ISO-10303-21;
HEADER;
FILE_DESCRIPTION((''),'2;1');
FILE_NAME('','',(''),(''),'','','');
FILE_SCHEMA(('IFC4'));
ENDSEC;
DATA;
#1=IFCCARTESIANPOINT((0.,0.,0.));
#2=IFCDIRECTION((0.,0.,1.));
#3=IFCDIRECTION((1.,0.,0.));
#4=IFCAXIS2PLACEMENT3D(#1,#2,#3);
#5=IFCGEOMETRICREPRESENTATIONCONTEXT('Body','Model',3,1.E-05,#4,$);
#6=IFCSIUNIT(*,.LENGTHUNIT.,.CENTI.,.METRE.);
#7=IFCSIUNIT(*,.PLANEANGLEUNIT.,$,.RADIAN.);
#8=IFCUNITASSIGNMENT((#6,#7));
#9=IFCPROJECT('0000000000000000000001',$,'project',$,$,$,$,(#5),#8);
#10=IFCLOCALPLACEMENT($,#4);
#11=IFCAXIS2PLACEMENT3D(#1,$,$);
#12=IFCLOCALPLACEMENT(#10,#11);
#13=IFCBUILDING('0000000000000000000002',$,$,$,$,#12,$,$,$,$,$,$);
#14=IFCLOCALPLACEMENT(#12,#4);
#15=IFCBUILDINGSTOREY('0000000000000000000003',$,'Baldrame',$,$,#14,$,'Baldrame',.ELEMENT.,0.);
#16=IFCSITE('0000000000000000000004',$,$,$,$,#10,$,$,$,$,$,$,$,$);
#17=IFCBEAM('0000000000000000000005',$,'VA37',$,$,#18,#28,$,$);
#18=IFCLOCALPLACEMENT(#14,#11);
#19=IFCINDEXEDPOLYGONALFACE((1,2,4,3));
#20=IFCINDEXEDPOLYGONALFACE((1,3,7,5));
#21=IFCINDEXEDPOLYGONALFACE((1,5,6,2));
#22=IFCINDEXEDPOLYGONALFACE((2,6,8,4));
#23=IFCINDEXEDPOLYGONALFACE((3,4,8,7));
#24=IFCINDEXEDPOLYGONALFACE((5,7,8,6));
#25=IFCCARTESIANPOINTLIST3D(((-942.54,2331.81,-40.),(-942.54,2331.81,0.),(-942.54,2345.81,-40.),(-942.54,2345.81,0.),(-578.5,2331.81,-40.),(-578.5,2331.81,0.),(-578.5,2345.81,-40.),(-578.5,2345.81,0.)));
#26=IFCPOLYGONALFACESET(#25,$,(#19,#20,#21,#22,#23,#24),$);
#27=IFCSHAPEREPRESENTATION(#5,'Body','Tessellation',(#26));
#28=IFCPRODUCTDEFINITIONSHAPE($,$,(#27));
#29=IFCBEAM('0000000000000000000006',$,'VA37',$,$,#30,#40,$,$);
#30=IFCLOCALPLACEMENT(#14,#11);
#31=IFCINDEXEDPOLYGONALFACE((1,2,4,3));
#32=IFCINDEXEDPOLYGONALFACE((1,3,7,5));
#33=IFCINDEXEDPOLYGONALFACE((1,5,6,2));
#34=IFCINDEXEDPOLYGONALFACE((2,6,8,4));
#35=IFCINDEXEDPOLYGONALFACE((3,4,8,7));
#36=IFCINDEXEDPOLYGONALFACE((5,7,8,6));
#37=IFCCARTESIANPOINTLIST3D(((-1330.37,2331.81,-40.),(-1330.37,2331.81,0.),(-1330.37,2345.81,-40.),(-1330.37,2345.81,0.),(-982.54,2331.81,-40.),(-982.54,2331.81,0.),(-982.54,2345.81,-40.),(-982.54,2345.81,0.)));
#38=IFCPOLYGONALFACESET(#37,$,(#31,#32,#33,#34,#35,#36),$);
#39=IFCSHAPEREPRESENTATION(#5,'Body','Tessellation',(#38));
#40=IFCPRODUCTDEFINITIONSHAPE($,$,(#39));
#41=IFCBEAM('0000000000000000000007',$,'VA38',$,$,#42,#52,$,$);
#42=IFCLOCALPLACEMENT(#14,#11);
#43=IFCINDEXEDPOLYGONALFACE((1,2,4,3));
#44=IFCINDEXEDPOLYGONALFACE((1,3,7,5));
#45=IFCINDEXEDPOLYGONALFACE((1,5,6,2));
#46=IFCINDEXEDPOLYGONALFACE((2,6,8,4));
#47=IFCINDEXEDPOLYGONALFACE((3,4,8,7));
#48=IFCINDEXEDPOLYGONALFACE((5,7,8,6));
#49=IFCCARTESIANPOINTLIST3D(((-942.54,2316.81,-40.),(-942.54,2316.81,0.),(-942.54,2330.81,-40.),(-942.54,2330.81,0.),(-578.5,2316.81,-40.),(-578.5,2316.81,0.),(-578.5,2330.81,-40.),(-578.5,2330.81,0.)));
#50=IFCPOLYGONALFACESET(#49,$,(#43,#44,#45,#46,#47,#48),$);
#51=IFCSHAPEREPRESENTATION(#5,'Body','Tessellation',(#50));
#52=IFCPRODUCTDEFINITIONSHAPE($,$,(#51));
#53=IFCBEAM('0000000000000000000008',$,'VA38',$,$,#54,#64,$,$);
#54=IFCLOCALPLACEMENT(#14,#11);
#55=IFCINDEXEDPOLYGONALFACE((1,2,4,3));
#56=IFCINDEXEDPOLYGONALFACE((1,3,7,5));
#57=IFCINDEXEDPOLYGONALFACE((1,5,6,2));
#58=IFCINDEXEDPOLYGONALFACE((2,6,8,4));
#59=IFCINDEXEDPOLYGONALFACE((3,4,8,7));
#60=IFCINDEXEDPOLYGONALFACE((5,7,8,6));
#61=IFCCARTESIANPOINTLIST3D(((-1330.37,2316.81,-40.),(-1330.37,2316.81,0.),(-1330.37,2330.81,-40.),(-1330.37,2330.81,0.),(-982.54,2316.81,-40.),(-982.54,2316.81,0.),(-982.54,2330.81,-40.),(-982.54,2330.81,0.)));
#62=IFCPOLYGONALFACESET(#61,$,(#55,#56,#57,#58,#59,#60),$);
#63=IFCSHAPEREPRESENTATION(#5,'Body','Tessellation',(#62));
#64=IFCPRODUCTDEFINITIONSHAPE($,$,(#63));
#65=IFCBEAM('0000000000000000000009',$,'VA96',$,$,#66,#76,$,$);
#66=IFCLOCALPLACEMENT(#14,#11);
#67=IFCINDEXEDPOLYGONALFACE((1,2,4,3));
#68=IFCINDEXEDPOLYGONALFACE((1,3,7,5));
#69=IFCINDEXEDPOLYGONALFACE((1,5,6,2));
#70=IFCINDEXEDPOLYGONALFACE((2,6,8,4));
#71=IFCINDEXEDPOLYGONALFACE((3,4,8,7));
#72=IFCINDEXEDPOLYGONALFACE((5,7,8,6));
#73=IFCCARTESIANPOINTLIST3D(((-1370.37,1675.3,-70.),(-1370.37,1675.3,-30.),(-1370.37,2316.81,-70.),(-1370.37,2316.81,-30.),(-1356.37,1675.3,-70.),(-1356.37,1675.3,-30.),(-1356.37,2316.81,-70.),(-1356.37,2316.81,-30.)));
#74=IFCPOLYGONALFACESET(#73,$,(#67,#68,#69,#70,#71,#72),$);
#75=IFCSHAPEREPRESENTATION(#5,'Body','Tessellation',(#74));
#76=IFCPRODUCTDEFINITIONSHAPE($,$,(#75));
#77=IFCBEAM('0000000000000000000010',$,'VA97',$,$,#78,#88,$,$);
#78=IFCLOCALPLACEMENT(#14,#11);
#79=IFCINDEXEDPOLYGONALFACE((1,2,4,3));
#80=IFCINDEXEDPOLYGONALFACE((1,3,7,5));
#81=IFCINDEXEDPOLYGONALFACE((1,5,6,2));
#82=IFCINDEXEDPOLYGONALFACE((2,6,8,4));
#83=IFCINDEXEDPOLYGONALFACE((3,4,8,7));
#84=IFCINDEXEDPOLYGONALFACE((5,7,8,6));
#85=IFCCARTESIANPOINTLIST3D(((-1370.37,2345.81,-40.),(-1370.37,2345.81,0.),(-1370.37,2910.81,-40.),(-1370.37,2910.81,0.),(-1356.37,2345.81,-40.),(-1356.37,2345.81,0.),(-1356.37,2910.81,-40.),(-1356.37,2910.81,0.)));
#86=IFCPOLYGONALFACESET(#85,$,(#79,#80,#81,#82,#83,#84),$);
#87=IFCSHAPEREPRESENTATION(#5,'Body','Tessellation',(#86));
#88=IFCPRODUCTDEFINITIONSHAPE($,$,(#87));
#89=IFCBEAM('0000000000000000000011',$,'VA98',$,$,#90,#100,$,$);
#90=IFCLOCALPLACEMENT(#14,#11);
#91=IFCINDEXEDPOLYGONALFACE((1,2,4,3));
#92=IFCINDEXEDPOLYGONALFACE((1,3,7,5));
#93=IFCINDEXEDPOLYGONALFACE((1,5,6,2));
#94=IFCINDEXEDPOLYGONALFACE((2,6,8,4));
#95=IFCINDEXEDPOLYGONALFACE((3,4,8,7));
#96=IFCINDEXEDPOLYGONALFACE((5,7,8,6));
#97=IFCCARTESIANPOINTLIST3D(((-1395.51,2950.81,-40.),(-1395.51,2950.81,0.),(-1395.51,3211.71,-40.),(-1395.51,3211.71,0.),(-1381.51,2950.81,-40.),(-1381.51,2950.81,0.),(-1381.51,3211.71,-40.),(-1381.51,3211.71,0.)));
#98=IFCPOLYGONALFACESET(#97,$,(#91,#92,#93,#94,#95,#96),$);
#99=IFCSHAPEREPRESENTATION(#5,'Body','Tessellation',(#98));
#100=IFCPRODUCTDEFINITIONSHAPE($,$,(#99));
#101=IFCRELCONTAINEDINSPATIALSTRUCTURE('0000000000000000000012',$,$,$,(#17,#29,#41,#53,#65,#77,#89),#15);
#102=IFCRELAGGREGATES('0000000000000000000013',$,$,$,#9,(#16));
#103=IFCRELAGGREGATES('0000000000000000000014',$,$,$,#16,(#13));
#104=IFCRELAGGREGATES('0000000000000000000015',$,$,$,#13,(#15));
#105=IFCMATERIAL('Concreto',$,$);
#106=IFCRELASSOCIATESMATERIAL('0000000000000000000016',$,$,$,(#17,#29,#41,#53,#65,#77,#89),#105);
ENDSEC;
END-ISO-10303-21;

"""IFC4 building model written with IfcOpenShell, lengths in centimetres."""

from ifc_helpers import new_model, si_unit, frame, origin, origin_with_axes, origin_2d_with_axis, place, context, project, spatial, rectangle, extrude, material, element, save


model = new_model("IFC4")

# Units and contexts
model_context = context("Model", 3, precision=1e-05, world=origin_with_axes(), identifier="Body")
ifc_project = project(units=[si_unit("LENGTHUNIT", "METRE", prefix="CENTI"), si_unit("PLANEANGLEUNIT", "RADIAN")], contexts=[model_context])

# Site, building, storey
site_placement = place(None, origin_with_axes())
site = spatial("IfcSite", under=ifc_project, at=site_placement)
building_placement = place(site_placement, origin())
building = spatial("IfcBuilding", under=site, at=building_placement)
storey_placement = place(building_placement, origin_with_axes())
storey = spatial("IfcBuildingStorey", under=building, at=storey_placement, Name="Baldrame", LongName="Baldrame", CompositionType="ELEMENT", Elevation=0.0)

# Shared definitions
ifc_material = material(Name="Concreto")

# Beams
beam_1_placement = place(storey_placement, frame((-760.52, 2338.81, 0.0), z_axis=(0.0, 0.0, 1.0), x_axis=(1.0, 0.0, 0.0)))
element("IfcBeam", 1, at=beam_1_placement, inside=storey, material=ifc_material, Name="VA37", context=model_context, shape_type="SolidModel", body=[
    extrude(rectangle(XDim=14.0, YDim=40.0, at=origin_2d_with_axis()), frame((-182.02, 0.0, -20.0), z_axis=(1.0, 0.0, 0.0), x_axis=(0.0, 1.0, 0.0)), (0.0, 0.0, 1.0), 364.04),
])
beam_2_placement = place(storey_placement, frame((-1156.45, 2338.81, 0.0), z_axis=(0.0, 0.0, 1.0), x_axis=(1.0, 0.0, 0.0)))
element("IfcBeam", 2, at=beam_2_placement, inside=storey, material=ifc_material, Name="VA37", context=model_context, shape_type="SolidModel", body=[
    extrude(rectangle(XDim=14.0, YDim=40.0, at=origin_2d_with_axis()), frame((-173.91, 0.0, -20.0), z_axis=(1.0, 0.0, 0.0), x_axis=(0.0, 1.0, 0.0)), (0.0, 0.0, 1.0), 347.83),
])
beam_3_placement = place(storey_placement, frame((-760.52, 2323.81, 0.0), z_axis=(0.0, 0.0, 1.0), x_axis=(1.0, 0.0, 0.0)))
element("IfcBeam", 3, at=beam_3_placement, inside=storey, material=ifc_material, Name="VA38", context=model_context, shape_type="SolidModel", body=[
    extrude(rectangle(XDim=14.0, YDim=40.0, at=origin_2d_with_axis()), frame((-182.02, 0.0, -20.0), z_axis=(1.0, 0.0, 0.0), x_axis=(0.0, 1.0, 0.0)), (0.0, 0.0, 1.0), 364.04),
])
beam_4_placement = place(storey_placement, frame((-1156.45, 2323.81, 0.0), z_axis=(0.0, 0.0, 1.0), x_axis=(1.0, 0.0, 0.0)))
element("IfcBeam", 4, at=beam_4_placement, inside=storey, material=ifc_material, Name="VA38", context=model_context, shape_type="SolidModel", body=[
    extrude(rectangle(XDim=14.0, YDim=40.0, at=origin_2d_with_axis()), frame((-173.91, 0.0, -20.0), z_axis=(1.0, 0.0, 0.0), x_axis=(0.0, 1.0, 0.0)), (0.0, 0.0, 1.0), 347.83),
])
beam_5_placement = place(storey_placement, frame((-1363.37, 1996.06, -30.0), z_axis=(0.0, 0.0, 1.0), x_axis=(1.0, 0.0, 0.0)))
element("IfcBeam", 5, at=beam_5_placement, inside=storey, material=ifc_material, Name="VA96", context=model_context, shape_type="SolidModel", body=[
    extrude(rectangle(XDim=14.0, YDim=40.0, at=origin_2d_with_axis()), frame((0.0, -320.75, -20.0), z_axis=(0.0, 1.0, 0.0), x_axis=(-1.0, 0.0, 0.0)), (0.0, 0.0, 1.0), 641.51),
])
beam_6_placement = place(storey_placement, frame((-1363.37, 2628.31, 0.0), z_axis=(0.0, 0.0, 1.0), x_axis=(1.0, 0.0, 0.0)))
element("IfcBeam", 6, at=beam_6_placement, inside=storey, material=ifc_material, Name="VA97", context=model_context, shape_type="SolidModel", body=[
    extrude(rectangle(XDim=14.0, YDim=40.0, at=origin_2d_with_axis()), frame((0.0, -282.5, -20.0), z_axis=(0.0, 1.0, 0.0), x_axis=(-1.0, 0.0, 0.0)), (0.0, 0.0, 1.0), 565.0),
])
beam_7_placement = place(storey_placement, frame((-1388.51, 3081.26, 0.0), z_axis=(0.0, 0.0, 1.0), x_axis=(1.0, 0.0, 0.0)))
element("IfcBeam", 7, at=beam_7_placement, inside=storey, material=ifc_material, Name="VA98", context=model_context, shape_type="SolidModel", body=[
    extrude(rectangle(XDim=14.0, YDim=40.0, at=origin_2d_with_axis()), frame((0.0, -130.45, -20.0), z_axis=(0.0, 1.0, 0.0), x_axis=(-1.0, 0.0, 0.0)), (0.0, 0.0, 1.0), 260.9),
])

save(model, "model.ifc")
